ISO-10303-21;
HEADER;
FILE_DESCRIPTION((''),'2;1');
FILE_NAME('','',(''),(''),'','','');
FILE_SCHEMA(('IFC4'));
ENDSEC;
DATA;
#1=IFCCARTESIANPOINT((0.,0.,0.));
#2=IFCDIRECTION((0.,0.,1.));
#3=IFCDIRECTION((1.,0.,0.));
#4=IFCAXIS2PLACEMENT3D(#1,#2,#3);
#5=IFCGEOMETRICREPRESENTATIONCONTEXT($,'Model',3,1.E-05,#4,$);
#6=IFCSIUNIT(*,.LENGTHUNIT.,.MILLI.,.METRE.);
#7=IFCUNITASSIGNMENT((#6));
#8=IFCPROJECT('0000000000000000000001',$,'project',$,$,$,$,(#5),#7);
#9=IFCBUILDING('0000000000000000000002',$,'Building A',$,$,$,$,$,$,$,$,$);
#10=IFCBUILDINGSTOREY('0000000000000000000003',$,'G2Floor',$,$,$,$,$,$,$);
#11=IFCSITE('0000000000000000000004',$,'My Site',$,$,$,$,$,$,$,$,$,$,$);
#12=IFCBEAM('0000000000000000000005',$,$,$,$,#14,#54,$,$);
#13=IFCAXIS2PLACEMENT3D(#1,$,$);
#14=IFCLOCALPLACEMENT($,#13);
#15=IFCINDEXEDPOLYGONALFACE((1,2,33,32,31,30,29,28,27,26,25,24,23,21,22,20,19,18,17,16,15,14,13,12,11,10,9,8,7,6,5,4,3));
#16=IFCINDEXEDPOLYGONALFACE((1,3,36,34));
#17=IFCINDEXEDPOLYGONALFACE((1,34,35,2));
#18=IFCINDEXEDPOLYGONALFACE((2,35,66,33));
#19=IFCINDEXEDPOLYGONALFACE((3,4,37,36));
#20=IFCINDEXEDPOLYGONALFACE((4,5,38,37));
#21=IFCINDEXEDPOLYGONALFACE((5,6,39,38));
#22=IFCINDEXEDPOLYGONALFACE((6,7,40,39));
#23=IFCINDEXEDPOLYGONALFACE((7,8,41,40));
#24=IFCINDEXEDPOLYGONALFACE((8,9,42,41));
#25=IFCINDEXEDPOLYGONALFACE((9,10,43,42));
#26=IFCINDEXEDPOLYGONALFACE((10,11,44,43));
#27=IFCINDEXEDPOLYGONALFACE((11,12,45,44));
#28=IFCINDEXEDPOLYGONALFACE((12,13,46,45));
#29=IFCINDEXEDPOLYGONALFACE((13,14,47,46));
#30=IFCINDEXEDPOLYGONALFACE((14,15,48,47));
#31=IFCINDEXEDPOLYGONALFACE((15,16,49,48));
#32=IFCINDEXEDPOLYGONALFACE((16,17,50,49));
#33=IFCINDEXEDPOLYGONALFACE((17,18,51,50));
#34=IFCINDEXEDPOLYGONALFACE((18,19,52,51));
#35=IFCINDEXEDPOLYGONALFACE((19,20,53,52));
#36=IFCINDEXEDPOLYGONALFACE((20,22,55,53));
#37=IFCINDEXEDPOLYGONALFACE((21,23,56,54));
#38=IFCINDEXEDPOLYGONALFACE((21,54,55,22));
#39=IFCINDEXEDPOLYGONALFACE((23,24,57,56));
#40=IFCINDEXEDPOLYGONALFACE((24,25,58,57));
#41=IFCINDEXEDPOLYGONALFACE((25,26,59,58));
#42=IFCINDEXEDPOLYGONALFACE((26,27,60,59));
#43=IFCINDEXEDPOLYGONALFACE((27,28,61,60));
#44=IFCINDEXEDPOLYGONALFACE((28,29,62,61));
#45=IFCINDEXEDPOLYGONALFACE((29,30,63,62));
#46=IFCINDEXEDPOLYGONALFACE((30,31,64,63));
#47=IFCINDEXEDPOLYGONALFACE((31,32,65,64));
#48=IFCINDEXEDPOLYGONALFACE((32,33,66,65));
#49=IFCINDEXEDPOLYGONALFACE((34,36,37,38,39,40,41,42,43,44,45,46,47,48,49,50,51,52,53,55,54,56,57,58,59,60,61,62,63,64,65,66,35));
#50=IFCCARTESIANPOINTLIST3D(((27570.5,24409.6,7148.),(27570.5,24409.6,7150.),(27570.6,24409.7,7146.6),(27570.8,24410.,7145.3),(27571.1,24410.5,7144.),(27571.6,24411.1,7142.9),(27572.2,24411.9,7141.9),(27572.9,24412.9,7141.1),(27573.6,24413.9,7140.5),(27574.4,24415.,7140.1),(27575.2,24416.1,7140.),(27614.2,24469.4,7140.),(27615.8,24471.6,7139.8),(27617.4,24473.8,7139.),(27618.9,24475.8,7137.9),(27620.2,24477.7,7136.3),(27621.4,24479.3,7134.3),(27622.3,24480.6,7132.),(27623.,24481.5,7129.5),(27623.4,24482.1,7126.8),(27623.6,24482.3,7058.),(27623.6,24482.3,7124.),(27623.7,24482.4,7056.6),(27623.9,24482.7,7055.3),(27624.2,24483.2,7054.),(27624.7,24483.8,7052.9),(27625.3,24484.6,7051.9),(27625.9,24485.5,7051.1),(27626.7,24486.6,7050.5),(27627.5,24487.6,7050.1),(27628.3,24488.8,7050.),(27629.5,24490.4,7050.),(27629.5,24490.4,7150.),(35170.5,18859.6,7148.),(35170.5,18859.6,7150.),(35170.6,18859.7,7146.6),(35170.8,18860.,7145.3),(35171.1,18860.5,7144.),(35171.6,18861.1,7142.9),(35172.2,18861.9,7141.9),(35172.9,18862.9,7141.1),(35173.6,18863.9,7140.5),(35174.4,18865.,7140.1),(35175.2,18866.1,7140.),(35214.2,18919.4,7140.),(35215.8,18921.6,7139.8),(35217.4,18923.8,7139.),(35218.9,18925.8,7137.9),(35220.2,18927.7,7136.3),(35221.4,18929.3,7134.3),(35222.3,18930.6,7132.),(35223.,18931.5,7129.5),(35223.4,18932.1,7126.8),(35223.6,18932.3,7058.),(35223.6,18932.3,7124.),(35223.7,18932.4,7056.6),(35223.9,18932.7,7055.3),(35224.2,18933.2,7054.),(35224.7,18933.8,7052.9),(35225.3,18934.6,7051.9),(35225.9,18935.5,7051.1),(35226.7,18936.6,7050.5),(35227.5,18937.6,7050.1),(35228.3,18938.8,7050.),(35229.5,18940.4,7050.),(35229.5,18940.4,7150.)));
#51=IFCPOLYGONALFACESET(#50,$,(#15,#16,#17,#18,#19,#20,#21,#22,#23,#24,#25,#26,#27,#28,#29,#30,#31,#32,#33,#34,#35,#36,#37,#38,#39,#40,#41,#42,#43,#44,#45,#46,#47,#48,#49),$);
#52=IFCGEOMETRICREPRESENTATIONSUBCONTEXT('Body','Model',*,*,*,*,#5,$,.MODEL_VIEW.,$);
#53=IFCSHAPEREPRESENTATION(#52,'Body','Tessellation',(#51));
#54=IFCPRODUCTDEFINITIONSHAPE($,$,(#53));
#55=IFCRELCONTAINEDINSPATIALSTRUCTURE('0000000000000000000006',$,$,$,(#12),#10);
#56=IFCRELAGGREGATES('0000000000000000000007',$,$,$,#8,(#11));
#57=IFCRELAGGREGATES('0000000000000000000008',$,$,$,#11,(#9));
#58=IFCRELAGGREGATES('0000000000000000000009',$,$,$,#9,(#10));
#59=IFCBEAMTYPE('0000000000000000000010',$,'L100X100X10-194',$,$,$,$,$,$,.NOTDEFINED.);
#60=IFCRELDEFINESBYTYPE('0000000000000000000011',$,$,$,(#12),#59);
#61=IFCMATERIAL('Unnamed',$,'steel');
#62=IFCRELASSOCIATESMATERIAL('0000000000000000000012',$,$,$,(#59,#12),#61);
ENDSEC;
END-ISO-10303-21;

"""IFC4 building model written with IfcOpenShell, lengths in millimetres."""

from ifc_helpers import new_model, si_unit, frame, origin_with_axes, place, context, subcontext, project, spatial, polyline, outline, extrude, material, material_profile, profile_set, profile_usage, type_object, element, save


model = new_model("IFC4")

# Units and contexts
model_context = context("Model", 3, precision=1e-05, world=origin_with_axes())
body_context = subcontext(model_context, "Body", "Model", "MODEL_VIEW")
ifc_project = project(units=[si_unit("LENGTHUNIT", "METRE", prefix="MILLI")], contexts=[model_context])

# Site, building, storey
site = spatial("IfcSite", under=ifc_project, Name="My Site")
building = spatial("IfcBuilding", under=site, Name="Building A")
storey = spatial("IfcBuildingStorey", under=building, Name="G2Floor")

# Beam
ifc_material_1 = material(Name="Unnamed", Category="steel")
ifc_material_profile_1 = material_profile(ifc_material_1, outline(polyline([(-50.0, -50.0), (50.0, -50.0), (50.0, -50.0), (50.0, -48.0), (50.0, -48.0), (49.9, -46.6), (49.9, -46.6), (49.5, -45.3), (49.5, -45.3), (48.9, -44.0), (48.9, -44.0), (48.1, -42.9), (48.1, -42.9), (47.1, -41.9), (47.1, -41.9), (46.0, -41.1), (46.0, -41.1), (44.7, -40.5), (44.7, -40.5), (43.4, -40.1), (43.4, -40.1), (42.0, -40.0), (42.0, -40.0), (-24.0, -40.0), (-24.0, -40.0), (-26.8, -39.8), (-26.8, -39.8), (-29.5, -39.0), (-29.5, -39.0), (-32.0, -37.9), (-32.0, -37.9), (-34.3, -36.3), (-34.3, -36.3), (-36.3, -34.3), (-36.3, -34.3), (-37.9, -32.0), (-37.9, -32.0), (-39.0, -29.5), (-39.0, -29.5), (-39.8, -26.8), (-39.8, -26.8), (-40.0, -24.0), (-40.0, -24.0), (-40.0, 42.0), (-40.0, 42.0), (-40.1, 43.4), (-40.1, 43.4), (-40.5, 44.7), (-40.5, 44.7), (-41.1, 46.0), (-41.1, 46.0), (-41.9, 47.1), (-41.9, 47.1), (-42.9, 48.1), (-42.9, 48.1), (-44.0, 48.9), (-44.0, 48.9), (-45.3, 49.5), (-45.3, 49.5), (-46.6, 49.9), (-46.6, 49.9), (-48.0, 50.0), (-48.0, 50.0), (-50.0, 50.0), (-50.0, 50.0), (-50.0, -50.0)])))
ifc_profile_set_1 = profile_set([ifc_material_profile_1], Name="L100X100X10-194")
ifc_profile_usage_1 = profile_usage(ifc_profile_set_1)
beam_type_1 = type_object("IfcBeamType", Name="L100X100X10-194", PredefinedType="NOTDEFINED", material=ifc_profile_set_1)
beam_1_placement = place(None, frame((27600.0, 24450.0, 7100.0), z_axis=(0.807586, -0.58975, 0.0), x_axis=(-0.58975, -0.807586, 0.0)))
element("IfcBeam", 1, at=beam_1_placement, inside=storey, type_object=beam_type_1, material=ifc_profile_usage_1, context=body_context, shape_type="SweptSolid", body=[
    extrude(outline(polyline([(-50.0, -50.0), (50.0, -50.0), (50.0, -50.0), (50.0, -48.0), (50.0, -48.0), (49.9, -46.6), (49.9, -46.6), (49.5, -45.3), (49.5, -45.3), (48.9, -44.0), (48.9, -44.0), (48.1, -42.9), (48.1, -42.9), (47.1, -41.9), (47.1, -41.9), (46.0, -41.1), (46.0, -41.1), (44.7, -40.5), (44.7, -40.5), (43.4, -40.1), (43.4, -40.1), (42.0, -40.0), (42.0, -40.0), (-24.0, -40.0), (-24.0, -40.0), (-26.8, -39.8), (-26.8, -39.8), (-29.5, -39.0), (-29.5, -39.0), (-32.0, -37.9), (-32.0, -37.9), (-34.3, -36.3), (-34.3, -36.3), (-36.3, -34.3), (-36.3, -34.3), (-37.9, -32.0), (-37.9, -32.0), (-39.0, -29.5), (-39.0, -29.5), (-39.8, -26.8), (-39.8, -26.8), (-40.0, -24.0), (-40.0, -24.0), (-40.0, 42.0), (-40.0, 42.0), (-40.1, 43.4), (-40.1, 43.4), (-40.5, 44.7), (-40.5, 44.7), (-41.1, 46.0), (-41.1, 46.0), (-41.9, 47.1), (-41.9, 47.1), (-42.9, 48.1), (-42.9, 48.1), (-44.0, 48.9), (-44.0, 48.9), (-45.3, 49.5), (-45.3, 49.5), (-46.6, 49.9), (-46.6, 49.9), (-48.0, 50.0), (-48.0, 50.0), (-50.0, 50.0), (-50.0, 50.0), (-50.0, -50.0)])), origin_with_axes(), (0.0, 0.0, 1.0), 9410.8),
])

save(model, "model.ifc")
